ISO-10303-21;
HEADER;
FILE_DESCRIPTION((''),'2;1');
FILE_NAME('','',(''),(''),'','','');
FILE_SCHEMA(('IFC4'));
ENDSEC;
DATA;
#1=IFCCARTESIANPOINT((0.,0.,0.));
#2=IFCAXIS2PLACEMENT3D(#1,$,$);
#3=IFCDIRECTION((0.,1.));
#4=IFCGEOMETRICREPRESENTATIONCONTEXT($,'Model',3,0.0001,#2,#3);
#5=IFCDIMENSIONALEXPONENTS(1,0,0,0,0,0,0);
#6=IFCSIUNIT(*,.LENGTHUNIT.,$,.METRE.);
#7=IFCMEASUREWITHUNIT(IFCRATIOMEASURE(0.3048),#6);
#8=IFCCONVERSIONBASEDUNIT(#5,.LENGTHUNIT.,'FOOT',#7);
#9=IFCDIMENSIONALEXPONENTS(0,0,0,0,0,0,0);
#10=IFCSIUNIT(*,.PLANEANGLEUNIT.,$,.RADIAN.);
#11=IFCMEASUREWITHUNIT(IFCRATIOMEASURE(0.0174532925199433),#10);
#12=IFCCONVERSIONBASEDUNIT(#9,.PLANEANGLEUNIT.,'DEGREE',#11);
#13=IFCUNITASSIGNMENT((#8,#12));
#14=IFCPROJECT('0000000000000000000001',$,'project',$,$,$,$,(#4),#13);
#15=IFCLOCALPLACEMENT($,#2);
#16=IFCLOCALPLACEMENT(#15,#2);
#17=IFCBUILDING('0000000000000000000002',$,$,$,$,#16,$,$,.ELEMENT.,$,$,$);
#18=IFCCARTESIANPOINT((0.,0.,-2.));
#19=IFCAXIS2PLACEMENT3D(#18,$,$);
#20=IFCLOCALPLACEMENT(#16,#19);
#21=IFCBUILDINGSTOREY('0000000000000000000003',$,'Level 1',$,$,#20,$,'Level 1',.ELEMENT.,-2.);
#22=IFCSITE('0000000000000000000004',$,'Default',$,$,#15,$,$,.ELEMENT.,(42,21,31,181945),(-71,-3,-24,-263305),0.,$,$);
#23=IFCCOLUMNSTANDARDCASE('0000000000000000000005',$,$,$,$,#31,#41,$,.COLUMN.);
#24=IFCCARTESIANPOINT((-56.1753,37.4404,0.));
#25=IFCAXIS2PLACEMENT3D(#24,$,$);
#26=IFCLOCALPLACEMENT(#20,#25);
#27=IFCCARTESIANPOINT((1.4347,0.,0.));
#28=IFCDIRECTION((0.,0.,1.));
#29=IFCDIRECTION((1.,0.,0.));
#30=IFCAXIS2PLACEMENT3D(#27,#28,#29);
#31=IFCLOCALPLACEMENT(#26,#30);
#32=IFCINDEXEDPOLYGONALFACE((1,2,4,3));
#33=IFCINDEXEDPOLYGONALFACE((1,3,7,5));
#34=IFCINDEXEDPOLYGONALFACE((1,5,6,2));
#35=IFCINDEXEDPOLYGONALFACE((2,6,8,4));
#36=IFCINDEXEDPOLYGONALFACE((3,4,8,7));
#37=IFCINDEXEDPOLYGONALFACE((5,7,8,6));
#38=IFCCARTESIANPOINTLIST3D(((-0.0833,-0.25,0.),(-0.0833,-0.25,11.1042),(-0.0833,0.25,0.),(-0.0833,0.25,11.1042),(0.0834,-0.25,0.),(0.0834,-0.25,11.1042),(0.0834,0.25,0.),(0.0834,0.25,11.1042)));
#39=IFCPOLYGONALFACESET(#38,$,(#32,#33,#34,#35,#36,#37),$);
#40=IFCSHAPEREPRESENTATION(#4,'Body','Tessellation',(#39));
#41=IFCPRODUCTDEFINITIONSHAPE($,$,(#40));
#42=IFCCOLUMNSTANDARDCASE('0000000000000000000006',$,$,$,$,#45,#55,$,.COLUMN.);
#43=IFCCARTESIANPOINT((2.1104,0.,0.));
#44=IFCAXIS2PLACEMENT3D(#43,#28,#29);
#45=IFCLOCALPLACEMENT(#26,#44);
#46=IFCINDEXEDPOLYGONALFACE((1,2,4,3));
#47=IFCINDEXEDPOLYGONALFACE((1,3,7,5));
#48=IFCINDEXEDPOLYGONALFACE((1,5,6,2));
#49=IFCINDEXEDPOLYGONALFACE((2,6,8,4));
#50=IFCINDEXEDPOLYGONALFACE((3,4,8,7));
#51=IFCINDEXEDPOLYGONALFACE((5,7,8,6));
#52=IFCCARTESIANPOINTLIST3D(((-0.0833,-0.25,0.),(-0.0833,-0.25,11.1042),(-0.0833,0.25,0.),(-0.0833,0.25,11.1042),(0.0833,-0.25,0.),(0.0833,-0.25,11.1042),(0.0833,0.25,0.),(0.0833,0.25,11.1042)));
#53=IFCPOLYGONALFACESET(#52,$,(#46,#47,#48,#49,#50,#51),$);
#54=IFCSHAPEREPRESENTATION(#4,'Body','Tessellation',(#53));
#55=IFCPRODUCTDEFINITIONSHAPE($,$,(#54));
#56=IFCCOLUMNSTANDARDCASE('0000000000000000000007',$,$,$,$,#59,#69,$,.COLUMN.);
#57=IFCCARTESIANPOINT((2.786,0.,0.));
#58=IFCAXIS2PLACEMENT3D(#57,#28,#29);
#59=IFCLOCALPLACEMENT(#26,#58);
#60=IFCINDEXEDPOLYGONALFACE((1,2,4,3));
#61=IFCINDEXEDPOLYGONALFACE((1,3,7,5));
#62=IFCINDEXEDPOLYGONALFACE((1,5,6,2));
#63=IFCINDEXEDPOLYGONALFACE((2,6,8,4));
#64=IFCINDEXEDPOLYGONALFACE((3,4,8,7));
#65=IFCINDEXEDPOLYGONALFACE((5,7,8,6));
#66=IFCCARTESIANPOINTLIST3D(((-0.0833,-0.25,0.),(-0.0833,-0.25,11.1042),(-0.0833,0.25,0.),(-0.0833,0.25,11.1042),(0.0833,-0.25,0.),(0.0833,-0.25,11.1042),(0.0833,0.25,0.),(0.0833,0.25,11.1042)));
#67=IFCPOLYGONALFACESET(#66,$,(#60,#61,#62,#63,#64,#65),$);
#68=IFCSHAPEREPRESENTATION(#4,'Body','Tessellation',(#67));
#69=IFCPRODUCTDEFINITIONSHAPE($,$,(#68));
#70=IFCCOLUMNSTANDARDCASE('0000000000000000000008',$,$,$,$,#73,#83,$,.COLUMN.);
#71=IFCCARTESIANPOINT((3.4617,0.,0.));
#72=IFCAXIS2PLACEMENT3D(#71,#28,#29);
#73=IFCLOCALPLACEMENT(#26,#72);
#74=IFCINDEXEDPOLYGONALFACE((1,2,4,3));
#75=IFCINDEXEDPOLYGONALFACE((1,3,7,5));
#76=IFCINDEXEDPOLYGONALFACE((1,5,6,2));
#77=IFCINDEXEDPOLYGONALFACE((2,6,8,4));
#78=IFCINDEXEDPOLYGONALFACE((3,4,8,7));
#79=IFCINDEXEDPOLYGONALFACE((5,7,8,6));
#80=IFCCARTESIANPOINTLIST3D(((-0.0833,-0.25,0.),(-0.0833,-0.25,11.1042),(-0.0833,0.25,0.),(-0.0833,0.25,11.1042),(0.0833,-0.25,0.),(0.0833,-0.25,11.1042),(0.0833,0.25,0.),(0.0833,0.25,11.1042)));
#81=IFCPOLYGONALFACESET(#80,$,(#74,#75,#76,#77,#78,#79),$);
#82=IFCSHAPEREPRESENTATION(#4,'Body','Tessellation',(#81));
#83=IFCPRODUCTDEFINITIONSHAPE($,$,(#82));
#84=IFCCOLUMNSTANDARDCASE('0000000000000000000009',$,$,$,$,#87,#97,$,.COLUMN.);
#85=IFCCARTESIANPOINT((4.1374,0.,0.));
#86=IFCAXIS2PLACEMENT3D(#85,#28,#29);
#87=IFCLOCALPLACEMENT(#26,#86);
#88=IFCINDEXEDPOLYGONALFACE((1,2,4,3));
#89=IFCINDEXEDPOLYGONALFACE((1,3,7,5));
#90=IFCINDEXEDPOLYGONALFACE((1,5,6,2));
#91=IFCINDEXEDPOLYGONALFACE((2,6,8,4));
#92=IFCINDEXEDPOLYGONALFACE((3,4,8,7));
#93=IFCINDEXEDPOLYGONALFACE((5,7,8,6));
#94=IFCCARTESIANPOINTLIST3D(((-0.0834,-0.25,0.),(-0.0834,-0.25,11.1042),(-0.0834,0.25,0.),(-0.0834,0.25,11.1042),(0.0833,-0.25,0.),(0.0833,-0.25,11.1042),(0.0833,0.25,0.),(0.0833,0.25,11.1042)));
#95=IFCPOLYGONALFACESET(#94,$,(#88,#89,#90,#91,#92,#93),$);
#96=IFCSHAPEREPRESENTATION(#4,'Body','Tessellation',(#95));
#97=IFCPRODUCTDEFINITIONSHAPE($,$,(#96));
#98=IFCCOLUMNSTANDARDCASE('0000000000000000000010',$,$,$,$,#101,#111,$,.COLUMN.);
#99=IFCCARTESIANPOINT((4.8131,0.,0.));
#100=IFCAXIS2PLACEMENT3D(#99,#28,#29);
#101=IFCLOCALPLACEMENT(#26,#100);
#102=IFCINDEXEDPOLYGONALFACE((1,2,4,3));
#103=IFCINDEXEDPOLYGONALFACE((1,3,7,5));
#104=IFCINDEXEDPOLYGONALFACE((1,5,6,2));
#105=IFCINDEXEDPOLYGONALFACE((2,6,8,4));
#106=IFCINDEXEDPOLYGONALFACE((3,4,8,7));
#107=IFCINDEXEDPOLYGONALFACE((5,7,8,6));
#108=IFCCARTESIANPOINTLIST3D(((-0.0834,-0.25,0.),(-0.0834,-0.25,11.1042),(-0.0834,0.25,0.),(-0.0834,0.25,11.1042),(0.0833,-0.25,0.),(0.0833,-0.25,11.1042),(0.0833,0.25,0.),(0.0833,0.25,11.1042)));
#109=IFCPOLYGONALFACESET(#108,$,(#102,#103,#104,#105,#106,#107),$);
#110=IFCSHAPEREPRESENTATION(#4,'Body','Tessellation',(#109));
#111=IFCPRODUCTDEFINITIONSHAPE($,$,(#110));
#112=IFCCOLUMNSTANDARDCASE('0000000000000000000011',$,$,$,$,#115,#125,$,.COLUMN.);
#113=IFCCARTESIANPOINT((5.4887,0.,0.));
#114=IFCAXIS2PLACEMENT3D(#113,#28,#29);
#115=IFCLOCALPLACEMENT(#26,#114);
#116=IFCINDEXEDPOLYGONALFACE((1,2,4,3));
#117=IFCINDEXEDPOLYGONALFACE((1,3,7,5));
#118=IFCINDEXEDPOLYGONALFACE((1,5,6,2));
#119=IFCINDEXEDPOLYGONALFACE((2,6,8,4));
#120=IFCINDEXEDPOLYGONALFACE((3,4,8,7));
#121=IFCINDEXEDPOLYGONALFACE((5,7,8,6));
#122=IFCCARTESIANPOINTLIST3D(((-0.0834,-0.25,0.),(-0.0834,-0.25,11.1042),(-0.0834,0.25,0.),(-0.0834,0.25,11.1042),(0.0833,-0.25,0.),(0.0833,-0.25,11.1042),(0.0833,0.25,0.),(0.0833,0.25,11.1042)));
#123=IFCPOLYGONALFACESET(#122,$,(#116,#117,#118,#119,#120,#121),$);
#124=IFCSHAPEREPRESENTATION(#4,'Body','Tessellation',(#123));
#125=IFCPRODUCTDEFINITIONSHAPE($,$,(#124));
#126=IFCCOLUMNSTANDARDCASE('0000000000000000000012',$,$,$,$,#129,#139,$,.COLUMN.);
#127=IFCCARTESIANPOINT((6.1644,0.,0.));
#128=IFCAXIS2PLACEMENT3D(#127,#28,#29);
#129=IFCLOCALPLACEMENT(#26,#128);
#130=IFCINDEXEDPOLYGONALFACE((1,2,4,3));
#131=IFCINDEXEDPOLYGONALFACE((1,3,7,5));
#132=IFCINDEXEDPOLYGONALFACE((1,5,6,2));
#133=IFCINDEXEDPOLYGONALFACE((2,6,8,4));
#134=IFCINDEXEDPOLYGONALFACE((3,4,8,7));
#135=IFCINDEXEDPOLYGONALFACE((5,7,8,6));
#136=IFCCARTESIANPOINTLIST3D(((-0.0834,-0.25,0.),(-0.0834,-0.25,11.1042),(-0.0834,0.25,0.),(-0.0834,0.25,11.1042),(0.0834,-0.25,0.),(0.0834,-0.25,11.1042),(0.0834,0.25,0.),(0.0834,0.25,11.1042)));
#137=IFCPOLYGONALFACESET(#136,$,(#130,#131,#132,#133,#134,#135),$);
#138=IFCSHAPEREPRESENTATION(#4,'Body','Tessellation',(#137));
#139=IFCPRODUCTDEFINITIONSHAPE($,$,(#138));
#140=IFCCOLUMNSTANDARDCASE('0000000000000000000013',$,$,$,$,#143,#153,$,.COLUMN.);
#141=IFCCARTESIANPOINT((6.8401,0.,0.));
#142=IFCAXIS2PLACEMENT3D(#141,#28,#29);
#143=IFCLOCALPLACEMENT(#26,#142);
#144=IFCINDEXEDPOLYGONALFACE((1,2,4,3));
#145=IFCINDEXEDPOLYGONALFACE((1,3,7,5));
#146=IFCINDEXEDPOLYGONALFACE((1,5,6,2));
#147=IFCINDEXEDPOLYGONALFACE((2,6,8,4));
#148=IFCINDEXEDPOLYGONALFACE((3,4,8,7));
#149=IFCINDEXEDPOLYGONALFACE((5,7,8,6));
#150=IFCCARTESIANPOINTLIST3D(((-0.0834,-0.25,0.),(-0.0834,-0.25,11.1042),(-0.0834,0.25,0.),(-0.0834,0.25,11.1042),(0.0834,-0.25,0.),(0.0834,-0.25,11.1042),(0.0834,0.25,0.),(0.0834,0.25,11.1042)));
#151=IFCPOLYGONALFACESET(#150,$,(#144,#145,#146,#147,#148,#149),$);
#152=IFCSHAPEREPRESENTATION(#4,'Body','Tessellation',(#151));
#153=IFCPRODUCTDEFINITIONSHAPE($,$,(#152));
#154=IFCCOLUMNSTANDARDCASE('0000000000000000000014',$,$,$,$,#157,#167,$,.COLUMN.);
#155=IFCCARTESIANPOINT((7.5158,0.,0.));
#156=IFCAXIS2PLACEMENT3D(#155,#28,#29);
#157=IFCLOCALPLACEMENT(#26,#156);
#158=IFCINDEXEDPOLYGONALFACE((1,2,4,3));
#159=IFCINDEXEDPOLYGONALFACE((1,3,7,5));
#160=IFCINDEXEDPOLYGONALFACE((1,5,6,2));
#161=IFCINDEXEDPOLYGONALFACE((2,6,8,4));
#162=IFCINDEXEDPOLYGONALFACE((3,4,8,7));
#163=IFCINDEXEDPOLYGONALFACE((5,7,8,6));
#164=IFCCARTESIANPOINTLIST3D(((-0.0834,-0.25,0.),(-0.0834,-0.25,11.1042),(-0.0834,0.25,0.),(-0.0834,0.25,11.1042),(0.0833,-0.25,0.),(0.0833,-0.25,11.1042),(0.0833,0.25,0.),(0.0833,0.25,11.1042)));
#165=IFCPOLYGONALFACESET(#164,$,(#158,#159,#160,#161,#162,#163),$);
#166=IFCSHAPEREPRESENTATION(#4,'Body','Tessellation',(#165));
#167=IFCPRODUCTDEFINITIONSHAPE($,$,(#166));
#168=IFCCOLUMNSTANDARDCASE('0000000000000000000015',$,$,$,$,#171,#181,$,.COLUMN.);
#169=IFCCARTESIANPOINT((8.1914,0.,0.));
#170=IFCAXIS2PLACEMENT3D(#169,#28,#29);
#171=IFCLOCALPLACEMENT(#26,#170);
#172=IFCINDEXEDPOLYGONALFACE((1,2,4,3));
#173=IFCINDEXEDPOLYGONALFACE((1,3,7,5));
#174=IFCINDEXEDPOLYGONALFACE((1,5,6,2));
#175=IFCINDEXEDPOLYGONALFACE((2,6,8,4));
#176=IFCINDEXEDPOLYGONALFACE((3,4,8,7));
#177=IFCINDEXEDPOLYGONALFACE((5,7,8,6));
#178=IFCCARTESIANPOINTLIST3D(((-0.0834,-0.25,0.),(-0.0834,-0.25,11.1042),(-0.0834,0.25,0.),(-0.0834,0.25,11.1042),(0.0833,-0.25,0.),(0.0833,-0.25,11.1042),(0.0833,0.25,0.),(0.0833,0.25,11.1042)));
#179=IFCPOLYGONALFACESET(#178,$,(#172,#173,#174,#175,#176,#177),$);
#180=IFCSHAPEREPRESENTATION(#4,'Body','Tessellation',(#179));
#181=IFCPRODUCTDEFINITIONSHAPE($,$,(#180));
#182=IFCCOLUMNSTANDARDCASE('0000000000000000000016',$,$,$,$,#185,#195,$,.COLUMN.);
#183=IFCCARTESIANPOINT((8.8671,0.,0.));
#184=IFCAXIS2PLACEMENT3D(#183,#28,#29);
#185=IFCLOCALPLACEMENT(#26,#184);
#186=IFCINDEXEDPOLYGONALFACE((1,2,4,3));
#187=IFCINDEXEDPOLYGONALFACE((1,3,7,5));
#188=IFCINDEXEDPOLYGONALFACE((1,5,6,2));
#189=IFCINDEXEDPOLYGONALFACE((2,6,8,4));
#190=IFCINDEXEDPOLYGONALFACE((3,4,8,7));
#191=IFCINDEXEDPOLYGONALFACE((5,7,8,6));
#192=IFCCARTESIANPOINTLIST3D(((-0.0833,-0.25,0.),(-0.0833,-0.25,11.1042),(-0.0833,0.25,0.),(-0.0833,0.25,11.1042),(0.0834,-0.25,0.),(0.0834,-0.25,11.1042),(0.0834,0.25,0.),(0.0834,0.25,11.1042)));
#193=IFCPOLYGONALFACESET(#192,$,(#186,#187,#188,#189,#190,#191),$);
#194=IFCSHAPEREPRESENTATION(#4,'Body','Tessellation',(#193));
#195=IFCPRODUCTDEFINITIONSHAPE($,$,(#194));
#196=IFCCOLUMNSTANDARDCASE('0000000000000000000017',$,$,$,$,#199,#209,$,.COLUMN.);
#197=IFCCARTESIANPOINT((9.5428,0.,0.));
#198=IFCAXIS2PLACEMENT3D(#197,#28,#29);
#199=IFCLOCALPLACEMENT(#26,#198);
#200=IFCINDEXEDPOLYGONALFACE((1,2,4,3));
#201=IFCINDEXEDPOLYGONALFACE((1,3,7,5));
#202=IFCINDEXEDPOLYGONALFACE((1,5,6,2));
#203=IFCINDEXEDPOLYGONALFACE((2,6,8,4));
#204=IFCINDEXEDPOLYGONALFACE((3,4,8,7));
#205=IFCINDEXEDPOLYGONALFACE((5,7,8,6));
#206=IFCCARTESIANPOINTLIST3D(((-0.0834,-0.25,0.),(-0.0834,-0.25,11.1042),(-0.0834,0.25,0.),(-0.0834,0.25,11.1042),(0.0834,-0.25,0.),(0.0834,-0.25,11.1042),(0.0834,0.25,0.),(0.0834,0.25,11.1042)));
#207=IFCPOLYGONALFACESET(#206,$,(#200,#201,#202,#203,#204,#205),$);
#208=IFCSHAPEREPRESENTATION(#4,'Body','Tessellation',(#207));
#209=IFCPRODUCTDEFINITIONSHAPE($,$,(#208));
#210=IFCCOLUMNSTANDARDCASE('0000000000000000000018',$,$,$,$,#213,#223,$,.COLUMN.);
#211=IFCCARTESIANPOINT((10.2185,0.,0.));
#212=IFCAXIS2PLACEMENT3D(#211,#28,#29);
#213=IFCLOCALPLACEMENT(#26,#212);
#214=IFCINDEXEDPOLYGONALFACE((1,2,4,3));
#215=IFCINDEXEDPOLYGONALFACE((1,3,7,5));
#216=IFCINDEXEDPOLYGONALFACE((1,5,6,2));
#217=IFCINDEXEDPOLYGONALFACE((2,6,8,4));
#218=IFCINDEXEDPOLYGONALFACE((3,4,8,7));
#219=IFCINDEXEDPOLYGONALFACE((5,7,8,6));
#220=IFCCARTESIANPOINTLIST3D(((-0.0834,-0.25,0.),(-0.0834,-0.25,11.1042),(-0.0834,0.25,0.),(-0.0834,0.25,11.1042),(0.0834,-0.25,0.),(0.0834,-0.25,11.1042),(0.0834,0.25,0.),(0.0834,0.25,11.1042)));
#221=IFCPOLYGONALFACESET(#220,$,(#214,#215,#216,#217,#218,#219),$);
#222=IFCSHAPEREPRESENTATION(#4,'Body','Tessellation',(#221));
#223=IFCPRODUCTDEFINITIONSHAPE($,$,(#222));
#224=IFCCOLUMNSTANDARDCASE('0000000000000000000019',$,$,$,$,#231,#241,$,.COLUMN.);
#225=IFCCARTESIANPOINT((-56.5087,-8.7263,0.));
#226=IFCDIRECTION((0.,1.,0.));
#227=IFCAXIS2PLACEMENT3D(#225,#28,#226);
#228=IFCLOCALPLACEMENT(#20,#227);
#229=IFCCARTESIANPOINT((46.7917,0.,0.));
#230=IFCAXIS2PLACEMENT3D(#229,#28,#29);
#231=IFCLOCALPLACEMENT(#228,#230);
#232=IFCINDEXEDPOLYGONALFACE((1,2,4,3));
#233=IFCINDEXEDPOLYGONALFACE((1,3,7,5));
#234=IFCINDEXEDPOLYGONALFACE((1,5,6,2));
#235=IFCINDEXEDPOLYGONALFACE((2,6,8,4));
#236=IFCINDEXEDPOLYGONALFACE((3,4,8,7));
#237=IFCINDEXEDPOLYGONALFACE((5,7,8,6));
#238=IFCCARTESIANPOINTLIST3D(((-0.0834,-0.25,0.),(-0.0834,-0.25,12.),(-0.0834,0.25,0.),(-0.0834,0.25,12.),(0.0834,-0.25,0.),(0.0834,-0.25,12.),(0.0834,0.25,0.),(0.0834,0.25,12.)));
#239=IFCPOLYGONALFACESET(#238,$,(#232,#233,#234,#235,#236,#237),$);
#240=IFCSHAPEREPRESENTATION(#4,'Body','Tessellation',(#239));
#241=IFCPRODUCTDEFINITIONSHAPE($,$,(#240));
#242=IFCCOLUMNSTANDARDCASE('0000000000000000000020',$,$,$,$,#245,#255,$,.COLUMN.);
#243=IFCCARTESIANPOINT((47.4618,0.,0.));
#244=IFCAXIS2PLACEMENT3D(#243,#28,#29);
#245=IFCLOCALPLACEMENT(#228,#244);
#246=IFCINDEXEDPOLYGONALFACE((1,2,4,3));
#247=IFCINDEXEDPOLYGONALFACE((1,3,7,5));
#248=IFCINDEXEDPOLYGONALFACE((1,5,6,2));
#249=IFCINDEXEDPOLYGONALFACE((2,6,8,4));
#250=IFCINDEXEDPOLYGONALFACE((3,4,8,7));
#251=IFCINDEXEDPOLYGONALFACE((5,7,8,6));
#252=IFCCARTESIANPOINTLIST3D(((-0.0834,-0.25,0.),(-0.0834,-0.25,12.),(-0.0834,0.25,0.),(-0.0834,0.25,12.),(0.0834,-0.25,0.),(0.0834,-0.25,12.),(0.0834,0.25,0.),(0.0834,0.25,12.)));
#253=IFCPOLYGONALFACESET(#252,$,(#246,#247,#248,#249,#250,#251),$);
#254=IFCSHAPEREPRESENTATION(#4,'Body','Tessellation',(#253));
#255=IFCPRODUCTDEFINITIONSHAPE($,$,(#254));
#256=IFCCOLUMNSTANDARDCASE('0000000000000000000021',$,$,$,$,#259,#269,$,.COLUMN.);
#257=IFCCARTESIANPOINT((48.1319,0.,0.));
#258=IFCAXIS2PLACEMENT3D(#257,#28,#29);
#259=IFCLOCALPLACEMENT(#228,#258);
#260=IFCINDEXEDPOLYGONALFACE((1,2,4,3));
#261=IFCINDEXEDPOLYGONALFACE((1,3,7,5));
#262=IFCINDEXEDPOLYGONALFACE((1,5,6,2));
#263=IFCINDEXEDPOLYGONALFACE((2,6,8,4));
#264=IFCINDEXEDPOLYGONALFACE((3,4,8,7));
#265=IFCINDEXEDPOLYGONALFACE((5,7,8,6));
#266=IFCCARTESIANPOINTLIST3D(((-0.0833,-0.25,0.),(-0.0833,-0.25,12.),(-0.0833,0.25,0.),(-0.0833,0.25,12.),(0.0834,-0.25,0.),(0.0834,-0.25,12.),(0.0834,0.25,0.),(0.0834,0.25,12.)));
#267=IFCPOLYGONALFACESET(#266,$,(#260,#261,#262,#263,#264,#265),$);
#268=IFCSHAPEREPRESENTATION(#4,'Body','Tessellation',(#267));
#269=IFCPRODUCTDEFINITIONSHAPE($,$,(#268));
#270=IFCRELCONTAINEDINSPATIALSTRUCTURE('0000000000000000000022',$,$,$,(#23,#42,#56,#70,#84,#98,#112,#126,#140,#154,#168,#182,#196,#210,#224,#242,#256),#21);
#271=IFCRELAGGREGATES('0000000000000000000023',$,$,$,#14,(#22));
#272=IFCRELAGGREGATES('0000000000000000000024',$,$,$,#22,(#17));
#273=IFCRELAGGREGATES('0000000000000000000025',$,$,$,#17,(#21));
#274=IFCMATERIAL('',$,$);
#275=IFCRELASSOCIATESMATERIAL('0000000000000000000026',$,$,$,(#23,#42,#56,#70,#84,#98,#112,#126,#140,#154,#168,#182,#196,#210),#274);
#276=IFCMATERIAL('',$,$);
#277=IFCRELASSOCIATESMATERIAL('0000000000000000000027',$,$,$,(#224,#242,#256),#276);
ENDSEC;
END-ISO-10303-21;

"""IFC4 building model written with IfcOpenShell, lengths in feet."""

from ifc_helpers import new_model, entity, si_unit, converted_unit, direction, frame, origin, place, context, project, spatial, rectangle, extrude, material, element, save


model = new_model("IFC4")

# Units and contexts
model_context = context("Model", 3, precision=0.0001, world=origin(), true_north=direction((0.0, 1.0)))
ifc_project = project(units=[converted_unit("LENGTHUNIT", "FOOT", entity("IfcRatioMeasure", 0.3048), si_unit("LENGTHUNIT", "METRE"), dimensions=[1, 0, 0, 0, 0, 0, 0]), converted_unit("PLANEANGLEUNIT", "DEGREE", entity("IfcRatioMeasure", 0.0174532925199433), si_unit("PLANEANGLEUNIT", "RADIAN"), dimensions=[0, 0, 0, 0, 0, 0, 0])], contexts=[model_context])

# Site, building, storey
site_placement = place(None, origin())
site = spatial("IfcSite", under=ifc_project, at=site_placement, Name="Default", CompositionType="ELEMENT", RefLatitude=(42, 21, 31, 181945), RefLongitude=(-71, -3, -24, -263305), RefElevation=0.0)
building_placement = place(site_placement, origin())
building = spatial("IfcBuilding", under=site, at=building_placement, CompositionType="ELEMENT")
storey_placement = place(building_placement, frame((0.0, 0.0, -2.0)))
storey = spatial("IfcBuildingStorey", under=building, at=storey_placement, Name="Level 1", LongName="Level 1", CompositionType="ELEMENT", Elevation=-2.0)

# Columns
ifc_material_1 = material(Name="")
placement_1 = place(storey_placement, frame((-56.1753, 37.4404, 0.0)))
for number, where, z_axis, x_axis in (
    (1, (1.4347, 0.0, 0.0), (0.0, 0.0, 1.0), (1.0, 0.0, 0.0)),
    (2, (2.1104, 0.0, 0.0), (0.0, 0.0, 1.0), (1.0, 0.0, 0.0)),
    (3, (2.786, 0.0, 0.0), (0.0, 0.0, 1.0), (1.0, 0.0, 0.0)),
    (4, (3.4617, 0.0, 0.0), (0.0, 0.0, 1.0), (1.0, 0.0, 0.0)),
    (5, (4.1374, 0.0, 0.0), (0.0, 0.0, 1.0), (1.0, 0.0, 0.0)),
    (6, (4.8131, 0.0, 0.0), (0.0, 0.0, 1.0), (1.0, 0.0, 0.0)),
    (7, (5.4887, 0.0, 0.0), (0.0, 0.0, 1.0), (1.0, 0.0, 0.0)),
    (8, (6.1644, 0.0, 0.0), (0.0, 0.0, 1.0), (1.0, 0.0, 0.0)),
    (9, (6.8401, 0.0, 0.0), (0.0, 0.0, 1.0), (1.0, 0.0, 0.0)),
    (10, (7.5158, 0.0, 0.0), (0.0, 0.0, 1.0), (1.0, 0.0, 0.0)),
    (11, (8.1914, 0.0, 0.0), (0.0, 0.0, 1.0), (1.0, 0.0, 0.0)),
    (12, (8.8671, 0.0, 0.0), (0.0, 0.0, 1.0), (1.0, 0.0, 0.0)),
    (13, (9.5428, 0.0, 0.0), (0.0, 0.0, 1.0), (1.0, 0.0, 0.0)),
    (14, (10.2185, 0.0, 0.0), (0.0, 0.0, 1.0), (1.0, 0.0, 0.0)),
):
    element("IfcColumnStandardCase", number, at=place(placement_1, frame(where, z_axis=z_axis, x_axis=x_axis)), inside=storey, material=ifc_material_1, PredefinedType="COLUMN", context=model_context, shape_type="SweptSolid", body=[
        extrude(rectangle(XDim=0.1667, YDim=0.5), origin(), (0.0, 0.0, 1.0), 11.1042),
    ])
ifc_material_2 = material(Name="")
placement_2 = place(storey_placement, frame((-56.5087, -8.7263, 0.0), z_axis=(0.0, 0.0, 1.0), x_axis=(0.0, 1.0, 0.0)))
for number, where, z_axis, x_axis in (
    (15, (46.7917, 0.0, 0.0), (0.0, 0.0, 1.0), (1.0, 0.0, 0.0)),
    (16, (47.4618, 0.0, 0.0), (0.0, 0.0, 1.0), (1.0, 0.0, 0.0)),
    (17, (48.1319, 0.0, 0.0), (0.0, 0.0, 1.0), (1.0, 0.0, 0.0)),
):
    element("IfcColumnStandardCase", number, at=place(placement_2, frame(where, z_axis=z_axis, x_axis=x_axis)), inside=storey, material=ifc_material_2, PredefinedType="COLUMN", context=model_context, shape_type="SweptSolid", body=[
        extrude(rectangle(XDim=0.1667, YDim=0.5), origin(), (0.0, 0.0, 1.0), 12.0),
    ])

save(model, "model.ifc")
